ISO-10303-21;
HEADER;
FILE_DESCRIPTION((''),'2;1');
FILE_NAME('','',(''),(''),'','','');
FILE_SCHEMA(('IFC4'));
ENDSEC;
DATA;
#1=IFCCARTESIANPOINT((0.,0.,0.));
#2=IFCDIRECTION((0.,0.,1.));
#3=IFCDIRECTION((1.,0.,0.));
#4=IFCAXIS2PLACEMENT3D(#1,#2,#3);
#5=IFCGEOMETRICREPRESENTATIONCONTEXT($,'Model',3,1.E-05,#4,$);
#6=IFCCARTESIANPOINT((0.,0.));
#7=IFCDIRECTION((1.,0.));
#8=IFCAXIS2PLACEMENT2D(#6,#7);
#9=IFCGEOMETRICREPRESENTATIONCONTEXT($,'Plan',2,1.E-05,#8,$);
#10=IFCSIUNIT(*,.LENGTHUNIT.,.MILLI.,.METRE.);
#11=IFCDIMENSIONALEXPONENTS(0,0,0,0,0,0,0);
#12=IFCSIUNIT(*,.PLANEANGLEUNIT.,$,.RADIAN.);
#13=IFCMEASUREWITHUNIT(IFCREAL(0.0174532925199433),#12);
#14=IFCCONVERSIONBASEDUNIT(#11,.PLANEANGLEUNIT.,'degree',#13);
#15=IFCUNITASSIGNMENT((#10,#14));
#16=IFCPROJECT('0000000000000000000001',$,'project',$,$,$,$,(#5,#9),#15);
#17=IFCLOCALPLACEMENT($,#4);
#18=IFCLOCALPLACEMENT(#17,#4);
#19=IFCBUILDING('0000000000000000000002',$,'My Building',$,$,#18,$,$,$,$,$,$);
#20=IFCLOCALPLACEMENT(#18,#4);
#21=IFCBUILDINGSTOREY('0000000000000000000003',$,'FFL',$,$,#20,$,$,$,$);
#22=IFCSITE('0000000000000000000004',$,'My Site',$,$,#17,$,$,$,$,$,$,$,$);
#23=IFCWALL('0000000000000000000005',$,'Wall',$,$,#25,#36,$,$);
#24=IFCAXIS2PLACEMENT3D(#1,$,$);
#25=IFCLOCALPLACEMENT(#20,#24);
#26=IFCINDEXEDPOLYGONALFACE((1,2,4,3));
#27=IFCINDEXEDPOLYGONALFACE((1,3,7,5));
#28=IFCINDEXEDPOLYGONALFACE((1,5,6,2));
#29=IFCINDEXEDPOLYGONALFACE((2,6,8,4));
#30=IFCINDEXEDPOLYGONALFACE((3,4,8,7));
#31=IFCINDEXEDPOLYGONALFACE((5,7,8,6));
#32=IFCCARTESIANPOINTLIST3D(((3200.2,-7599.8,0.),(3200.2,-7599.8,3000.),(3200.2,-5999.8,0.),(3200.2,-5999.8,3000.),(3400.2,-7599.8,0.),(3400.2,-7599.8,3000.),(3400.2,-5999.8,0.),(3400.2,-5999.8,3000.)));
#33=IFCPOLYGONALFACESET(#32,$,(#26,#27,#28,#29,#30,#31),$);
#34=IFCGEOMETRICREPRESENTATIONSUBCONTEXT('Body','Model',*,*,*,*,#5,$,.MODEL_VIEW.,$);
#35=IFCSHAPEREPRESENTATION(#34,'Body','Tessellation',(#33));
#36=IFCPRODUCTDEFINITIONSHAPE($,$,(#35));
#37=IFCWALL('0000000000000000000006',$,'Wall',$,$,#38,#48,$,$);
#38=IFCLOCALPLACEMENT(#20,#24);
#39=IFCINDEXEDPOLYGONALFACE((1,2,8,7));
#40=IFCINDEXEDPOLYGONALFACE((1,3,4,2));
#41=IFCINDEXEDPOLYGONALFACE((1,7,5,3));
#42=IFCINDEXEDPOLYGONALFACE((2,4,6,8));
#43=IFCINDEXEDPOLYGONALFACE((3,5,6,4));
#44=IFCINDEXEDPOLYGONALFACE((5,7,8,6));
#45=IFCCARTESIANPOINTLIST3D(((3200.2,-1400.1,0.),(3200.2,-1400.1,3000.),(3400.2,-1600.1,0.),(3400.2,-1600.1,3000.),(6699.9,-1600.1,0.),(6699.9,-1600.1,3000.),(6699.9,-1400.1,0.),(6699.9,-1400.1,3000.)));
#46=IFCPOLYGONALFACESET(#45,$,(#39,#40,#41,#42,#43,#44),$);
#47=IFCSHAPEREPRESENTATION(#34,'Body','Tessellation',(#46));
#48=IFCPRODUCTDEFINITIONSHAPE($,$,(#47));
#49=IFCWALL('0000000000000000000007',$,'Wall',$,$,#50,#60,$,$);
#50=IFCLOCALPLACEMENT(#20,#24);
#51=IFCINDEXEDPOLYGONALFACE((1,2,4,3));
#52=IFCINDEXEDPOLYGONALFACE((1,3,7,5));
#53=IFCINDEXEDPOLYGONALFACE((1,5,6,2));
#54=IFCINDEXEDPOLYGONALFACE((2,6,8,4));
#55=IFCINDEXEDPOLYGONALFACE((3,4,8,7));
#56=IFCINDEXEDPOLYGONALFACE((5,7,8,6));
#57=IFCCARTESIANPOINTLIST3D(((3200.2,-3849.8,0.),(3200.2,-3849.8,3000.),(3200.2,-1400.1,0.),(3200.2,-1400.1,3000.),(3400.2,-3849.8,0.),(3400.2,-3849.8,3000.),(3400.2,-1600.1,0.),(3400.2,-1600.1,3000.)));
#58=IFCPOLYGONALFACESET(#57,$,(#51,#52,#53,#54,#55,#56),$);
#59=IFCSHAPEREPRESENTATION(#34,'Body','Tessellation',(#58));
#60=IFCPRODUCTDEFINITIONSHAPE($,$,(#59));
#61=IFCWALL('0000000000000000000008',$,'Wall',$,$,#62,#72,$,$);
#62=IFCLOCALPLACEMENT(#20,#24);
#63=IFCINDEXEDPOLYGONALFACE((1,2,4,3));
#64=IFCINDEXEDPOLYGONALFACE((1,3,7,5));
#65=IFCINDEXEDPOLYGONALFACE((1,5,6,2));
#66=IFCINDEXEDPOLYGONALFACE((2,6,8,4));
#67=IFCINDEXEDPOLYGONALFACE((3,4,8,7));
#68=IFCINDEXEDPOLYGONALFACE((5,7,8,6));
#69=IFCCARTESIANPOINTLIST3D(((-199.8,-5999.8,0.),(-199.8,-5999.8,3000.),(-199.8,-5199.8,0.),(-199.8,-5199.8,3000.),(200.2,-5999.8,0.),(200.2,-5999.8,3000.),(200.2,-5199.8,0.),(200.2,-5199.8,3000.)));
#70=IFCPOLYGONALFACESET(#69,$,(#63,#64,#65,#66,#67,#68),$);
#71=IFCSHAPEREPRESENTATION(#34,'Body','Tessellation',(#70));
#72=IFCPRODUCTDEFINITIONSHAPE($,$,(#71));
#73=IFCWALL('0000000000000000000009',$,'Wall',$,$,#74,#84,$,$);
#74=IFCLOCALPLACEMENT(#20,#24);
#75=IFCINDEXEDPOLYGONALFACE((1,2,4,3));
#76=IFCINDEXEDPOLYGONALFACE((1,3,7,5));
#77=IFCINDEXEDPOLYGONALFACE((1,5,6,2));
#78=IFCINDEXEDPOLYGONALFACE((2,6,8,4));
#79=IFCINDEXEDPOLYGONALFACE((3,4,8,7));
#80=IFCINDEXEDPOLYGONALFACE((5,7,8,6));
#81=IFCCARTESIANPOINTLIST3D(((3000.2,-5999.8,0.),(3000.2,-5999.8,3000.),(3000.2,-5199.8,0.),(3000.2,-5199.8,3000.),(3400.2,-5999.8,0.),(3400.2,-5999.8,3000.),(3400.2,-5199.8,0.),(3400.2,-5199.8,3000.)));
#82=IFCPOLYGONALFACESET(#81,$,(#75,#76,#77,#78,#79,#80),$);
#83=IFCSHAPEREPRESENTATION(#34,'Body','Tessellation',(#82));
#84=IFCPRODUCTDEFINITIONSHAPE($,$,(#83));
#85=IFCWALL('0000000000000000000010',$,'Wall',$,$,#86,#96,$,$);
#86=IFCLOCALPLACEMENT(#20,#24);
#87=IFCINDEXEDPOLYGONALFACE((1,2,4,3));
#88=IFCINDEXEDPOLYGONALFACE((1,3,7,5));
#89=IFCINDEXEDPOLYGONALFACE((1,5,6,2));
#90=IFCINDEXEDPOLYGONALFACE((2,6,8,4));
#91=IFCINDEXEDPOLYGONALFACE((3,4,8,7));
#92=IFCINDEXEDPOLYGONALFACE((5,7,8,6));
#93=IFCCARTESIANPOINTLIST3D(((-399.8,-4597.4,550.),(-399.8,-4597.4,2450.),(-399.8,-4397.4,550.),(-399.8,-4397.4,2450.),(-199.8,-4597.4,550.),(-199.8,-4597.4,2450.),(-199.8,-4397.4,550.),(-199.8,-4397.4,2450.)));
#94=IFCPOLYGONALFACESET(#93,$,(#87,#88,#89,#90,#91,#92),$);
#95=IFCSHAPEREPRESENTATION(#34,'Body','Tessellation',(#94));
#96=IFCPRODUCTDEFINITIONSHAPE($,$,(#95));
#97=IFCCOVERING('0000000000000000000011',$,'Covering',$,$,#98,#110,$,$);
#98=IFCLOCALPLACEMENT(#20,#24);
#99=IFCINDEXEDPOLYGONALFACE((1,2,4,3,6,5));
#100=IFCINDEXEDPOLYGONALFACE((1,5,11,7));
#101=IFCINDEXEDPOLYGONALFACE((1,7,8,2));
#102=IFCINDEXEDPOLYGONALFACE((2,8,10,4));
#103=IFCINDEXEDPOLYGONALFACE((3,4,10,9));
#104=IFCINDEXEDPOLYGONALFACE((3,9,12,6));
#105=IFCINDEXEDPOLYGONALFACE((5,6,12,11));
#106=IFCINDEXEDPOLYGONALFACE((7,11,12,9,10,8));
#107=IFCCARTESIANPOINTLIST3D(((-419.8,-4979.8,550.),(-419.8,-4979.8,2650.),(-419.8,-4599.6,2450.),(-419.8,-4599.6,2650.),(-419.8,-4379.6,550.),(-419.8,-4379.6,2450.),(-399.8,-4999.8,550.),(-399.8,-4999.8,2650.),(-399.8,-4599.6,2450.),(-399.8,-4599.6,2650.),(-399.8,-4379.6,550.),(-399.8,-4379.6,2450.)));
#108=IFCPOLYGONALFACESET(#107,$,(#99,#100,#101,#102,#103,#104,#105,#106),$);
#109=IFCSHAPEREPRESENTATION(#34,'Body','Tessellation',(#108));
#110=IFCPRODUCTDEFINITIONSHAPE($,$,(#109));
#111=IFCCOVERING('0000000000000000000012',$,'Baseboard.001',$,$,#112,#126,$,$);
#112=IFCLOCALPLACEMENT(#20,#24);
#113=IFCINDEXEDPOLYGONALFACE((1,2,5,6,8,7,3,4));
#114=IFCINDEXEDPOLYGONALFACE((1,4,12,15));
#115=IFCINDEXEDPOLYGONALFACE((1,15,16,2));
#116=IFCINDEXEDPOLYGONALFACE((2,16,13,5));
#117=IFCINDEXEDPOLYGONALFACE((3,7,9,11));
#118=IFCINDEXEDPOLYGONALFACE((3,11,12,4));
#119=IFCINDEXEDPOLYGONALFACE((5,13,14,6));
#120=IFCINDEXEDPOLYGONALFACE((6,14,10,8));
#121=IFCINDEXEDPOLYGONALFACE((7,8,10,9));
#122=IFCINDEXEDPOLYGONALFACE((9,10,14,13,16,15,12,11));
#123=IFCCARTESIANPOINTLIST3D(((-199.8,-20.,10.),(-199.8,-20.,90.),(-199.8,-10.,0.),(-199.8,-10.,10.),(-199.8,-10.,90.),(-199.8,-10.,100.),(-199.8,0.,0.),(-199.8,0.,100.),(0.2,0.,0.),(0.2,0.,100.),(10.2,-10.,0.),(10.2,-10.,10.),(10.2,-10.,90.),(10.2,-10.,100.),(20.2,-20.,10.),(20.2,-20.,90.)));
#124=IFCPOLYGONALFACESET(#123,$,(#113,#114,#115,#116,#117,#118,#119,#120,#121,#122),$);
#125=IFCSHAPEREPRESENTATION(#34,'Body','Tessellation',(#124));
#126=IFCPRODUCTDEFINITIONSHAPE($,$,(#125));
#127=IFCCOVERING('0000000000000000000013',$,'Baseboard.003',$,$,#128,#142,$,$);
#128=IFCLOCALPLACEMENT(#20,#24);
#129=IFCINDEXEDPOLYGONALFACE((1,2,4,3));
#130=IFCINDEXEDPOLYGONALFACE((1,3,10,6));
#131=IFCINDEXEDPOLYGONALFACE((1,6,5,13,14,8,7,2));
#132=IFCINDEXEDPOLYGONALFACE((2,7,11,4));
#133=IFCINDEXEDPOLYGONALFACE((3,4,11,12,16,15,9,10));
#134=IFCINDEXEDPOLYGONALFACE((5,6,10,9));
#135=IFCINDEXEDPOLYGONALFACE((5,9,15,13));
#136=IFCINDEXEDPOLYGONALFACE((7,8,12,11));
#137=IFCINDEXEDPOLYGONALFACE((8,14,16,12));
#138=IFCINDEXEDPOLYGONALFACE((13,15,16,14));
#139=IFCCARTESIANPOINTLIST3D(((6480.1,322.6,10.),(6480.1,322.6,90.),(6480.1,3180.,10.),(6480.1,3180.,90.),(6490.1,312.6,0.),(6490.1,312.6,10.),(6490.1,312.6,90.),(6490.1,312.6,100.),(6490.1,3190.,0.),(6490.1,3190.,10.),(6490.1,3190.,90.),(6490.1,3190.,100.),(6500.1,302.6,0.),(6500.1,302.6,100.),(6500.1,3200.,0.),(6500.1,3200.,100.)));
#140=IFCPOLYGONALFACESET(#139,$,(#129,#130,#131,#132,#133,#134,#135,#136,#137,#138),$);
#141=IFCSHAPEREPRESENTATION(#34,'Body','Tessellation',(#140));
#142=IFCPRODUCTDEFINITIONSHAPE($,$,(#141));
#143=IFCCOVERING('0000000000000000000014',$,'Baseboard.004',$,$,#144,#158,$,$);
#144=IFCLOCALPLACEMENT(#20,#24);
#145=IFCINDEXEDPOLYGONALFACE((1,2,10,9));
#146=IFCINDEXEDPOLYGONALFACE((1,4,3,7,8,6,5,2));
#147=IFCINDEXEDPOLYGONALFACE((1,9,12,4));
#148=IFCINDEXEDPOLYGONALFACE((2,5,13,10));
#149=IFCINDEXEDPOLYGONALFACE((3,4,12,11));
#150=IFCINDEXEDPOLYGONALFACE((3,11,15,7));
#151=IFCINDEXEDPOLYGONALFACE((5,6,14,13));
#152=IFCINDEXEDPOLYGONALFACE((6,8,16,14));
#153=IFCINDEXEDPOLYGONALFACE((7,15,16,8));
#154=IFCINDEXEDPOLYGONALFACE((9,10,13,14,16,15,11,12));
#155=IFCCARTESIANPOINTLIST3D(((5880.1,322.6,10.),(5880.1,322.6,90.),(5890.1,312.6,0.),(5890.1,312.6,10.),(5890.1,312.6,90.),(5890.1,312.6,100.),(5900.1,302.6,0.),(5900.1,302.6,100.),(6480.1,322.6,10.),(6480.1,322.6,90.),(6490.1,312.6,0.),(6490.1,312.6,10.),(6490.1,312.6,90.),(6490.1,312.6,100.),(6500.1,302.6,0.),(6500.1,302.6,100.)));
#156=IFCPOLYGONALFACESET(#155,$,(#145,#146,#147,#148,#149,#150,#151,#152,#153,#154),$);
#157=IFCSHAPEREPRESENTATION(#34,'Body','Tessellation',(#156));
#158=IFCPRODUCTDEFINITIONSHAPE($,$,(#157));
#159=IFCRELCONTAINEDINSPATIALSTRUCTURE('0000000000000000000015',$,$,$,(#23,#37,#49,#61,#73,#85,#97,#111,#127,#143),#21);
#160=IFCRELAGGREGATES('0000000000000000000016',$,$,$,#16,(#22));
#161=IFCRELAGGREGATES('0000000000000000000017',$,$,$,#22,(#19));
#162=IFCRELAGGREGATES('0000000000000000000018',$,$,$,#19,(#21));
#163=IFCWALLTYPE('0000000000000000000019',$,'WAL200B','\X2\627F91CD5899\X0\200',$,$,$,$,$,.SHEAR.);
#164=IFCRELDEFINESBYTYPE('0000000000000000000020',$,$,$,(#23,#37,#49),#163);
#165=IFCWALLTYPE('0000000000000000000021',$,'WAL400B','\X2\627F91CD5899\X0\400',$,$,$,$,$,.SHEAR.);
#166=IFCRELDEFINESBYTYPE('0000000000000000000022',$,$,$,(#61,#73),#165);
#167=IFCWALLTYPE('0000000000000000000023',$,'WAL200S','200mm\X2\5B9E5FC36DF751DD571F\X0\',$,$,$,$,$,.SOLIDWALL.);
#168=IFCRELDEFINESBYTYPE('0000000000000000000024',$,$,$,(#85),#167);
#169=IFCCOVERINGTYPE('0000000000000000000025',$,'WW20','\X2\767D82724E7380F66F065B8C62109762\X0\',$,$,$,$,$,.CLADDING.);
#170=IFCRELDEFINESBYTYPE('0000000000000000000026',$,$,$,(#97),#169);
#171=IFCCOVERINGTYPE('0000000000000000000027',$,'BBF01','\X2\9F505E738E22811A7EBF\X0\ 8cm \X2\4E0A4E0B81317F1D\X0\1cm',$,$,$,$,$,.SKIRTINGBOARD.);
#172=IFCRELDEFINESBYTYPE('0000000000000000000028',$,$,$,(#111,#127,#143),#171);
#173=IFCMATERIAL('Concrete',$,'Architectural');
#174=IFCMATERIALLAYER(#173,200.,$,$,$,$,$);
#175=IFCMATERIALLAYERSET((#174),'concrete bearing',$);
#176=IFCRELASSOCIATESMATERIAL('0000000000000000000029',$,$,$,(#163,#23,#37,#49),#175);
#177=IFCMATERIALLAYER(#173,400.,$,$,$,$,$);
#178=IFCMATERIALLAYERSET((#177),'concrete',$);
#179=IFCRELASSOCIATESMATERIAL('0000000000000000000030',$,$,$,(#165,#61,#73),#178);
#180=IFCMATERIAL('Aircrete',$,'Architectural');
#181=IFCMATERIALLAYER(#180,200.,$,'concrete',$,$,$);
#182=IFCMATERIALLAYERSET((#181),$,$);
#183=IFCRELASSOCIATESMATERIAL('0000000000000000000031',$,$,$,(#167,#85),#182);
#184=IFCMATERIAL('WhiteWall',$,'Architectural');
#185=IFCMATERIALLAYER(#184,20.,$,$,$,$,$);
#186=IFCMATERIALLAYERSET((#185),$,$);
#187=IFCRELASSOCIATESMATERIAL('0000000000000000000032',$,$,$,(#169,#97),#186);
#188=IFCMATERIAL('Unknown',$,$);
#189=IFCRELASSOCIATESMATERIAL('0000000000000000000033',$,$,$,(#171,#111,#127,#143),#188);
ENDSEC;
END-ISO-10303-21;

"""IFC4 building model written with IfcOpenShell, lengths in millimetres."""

from ifc_helpers import new_model, entity, si_unit, converted_unit, frame, origin_with_axes, origin_2d_with_axis, place, context, subcontext, project, spatial, line, indexed_curve, outline, extrude, clip, halfspace, material, layer, layer_set, layer_usage, material_profile, profile_set, profile_usage, type_object, element, save


model = new_model("IFC4")

# Units and contexts
model_context = context("Model", 3, precision=1e-05, world=origin_with_axes())
plan_context = context("Plan", 2, precision=1e-05, world=origin_2d_with_axis())
body_context_1 = subcontext(model_context, "Body", "Model", "MODEL_VIEW")
ifc_project = project(units=[si_unit("LENGTHUNIT", "METRE", prefix="MILLI"), converted_unit("PLANEANGLEUNIT", "degree", entity("IfcReal", 0.0174532925199433), si_unit("PLANEANGLEUNIT", "RADIAN"), dimensions=[0, 0, 0, 0, 0, 0, 0])], contexts=[model_context, plan_context])

# Site, building, storey
site_placement = place(None, origin_with_axes())
site = spatial("IfcSite", under=ifc_project, at=site_placement, Name="My Site")
building_placement = place(site_placement, origin_with_axes())
building = spatial("IfcBuilding", under=site, at=building_placement, Name="My Building")
storey_placement = place(building_placement, origin_with_axes())
storey = spatial("IfcBuildingStorey", under=building, at=storey_placement, Name="FFL")

# Shared definitions
ifc_material_1 = material(Name="Aircrete", Category="Architectural")

# Walls
ifc_material_2 = material(Name="Concrete", Category="Architectural")
ifc_layer_1 = layer(ifc_material_2, 200.0)
ifc_layer_set_1 = layer_set([ifc_layer_1], Name="concrete bearing")
wall_type_1 = type_object("IfcWallType", Name="WAL200B", Description="承重墙200", PredefinedType="SHEAR", material=ifc_layer_set_1)
ifc_layer_usage_1 = layer_usage(ifc_layer_set_1, "AXIS2", "NEGATIVE", 0.0)
wall_1_placement = place(storey_placement, frame((3400.2, -5999.8, 0.0), z_axis=(0.0, 0.0, 1.0), x_axis=(0.0, -1.0, 0.0)))
element("IfcWall", 1, at=wall_1_placement, inside=storey, type_object=wall_type_1, material=ifc_layer_usage_1, Name="Wall", context=body_context_1, shape_type="SweptSolid", body=[
    extrude(outline(indexed_curve([(0.0, -200.0), (0.0, 0.0), (1600.0, 0.0), (1600.0, -200.0)], segments=[line(1, 2, 3, 4, 1)])), origin_with_axes(), (0.0, 0.0, 1.0), 3000.0),
])
ifc_layer_usage_2 = layer_usage(ifc_layer_set_1, "AXIS2", "NEGATIVE", 0.0)
wall_2_placement = place(storey_placement, frame((6699.9, -1600.1, 0.0), z_axis=(0.0, 0.0, 1.0), x_axis=(-1.0, 0.000006, 0.0)))
element("IfcWall", 2, at=wall_2_placement, inside=storey, type_object=wall_type_1, material=ifc_layer_usage_2, Name="Wall", context=body_context_1, shape_type="SweptSolid", body=[
    extrude(outline(indexed_curve([(0.0, -200.0), (0.0, 0.0), (3299.7, 0.0), (3499.7, -200.0)], segments=[line(1, 2, 3, 4, 1)])), origin_with_axes(), (0.0, 0.0, 1.0), 3000.0),
])
ifc_layer_usage_3 = layer_usage(ifc_layer_set_1, "AXIS2", "NEGATIVE", 0.0)
wall_3_placement = place(storey_placement, frame((3200.2, -3849.8, 0.0), z_axis=(0.0, 0.0, 1.0), x_axis=(0.0, 1.0, 0.0)))
element("IfcWall", 3, at=wall_3_placement, inside=storey, type_object=wall_type_1, material=ifc_layer_usage_3, Name="Wall", context=body_context_1, shape_type="SweptSolid", body=[
    extrude(outline(indexed_curve([(0.0, -200.0), (0.0, 0.0), (2449.7, 0.0), (2249.7, -200.0)], segments=[line(1, 2, 3, 4, 1)])), origin_with_axes(), (0.0, 0.0, 1.0), 3000.0),
])
ifc_layer_2 = layer(ifc_material_2, 400.0)
ifc_layer_set_2 = layer_set([ifc_layer_2], Name="concrete")
ifc_layer_usage_4 = layer_usage(ifc_layer_set_2, "AXIS2", "POSITIVE", 0.0)
wall_type_2 = type_object("IfcWallType", Name="WAL400B", Description="承重墙400", PredefinedType="SHEAR", material=ifc_layer_set_2)
wall_4_placement = place(storey_placement, frame((-199.8, -5199.8, 0.0), z_axis=(0.0, 0.0, 1.0), x_axis=(0.0, -1.0, 0.0)))
element("IfcWall", 4, at=wall_4_placement, inside=storey, type_object=wall_type_2, material=ifc_layer_usage_4, Name="Wall", context=body_context_1, shape_type="SweptSolid", body=[
    extrude(outline(indexed_curve([(0.0, 0.0), (0.0, 400.0), (800.0, 400.0), (800.0, 0.0)], segments=[line(1, 2, 3, 4, 1)])), origin_with_axes(), (0.0, 0.0, 1.0), 3000.0),
])
ifc_layer_usage_5 = layer_usage(ifc_layer_set_2, "AXIS2", "POSITIVE", 0.0)
wall_5_placement = place(storey_placement, frame((3400.2, -5999.8, 0.0), z_axis=(0.0, 0.0, 1.0), x_axis=(0.000001, 1.0, 0.0)))
element("IfcWall", 5, at=wall_5_placement, inside=storey, type_object=wall_type_2, material=ifc_layer_usage_5, Name="Wall", context=body_context_1, shape_type="SweptSolid", body=[
    extrude(outline(indexed_curve([(0.0, 0.0), (0.0, 400.0), (800.0, 400.0), (800.0, 0.0)], segments=[line(1, 2, 3, 4, 1)])), origin_with_axes(), (0.0, 0.0, 1.0), 3000.0),
])
ifc_layer_3 = layer(ifc_material_1, 200.0, Name="concrete")
ifc_layer_set_3 = layer_set([ifc_layer_3])
ifc_layer_usage_6 = layer_usage(ifc_layer_set_3, "AXIS2", "NEGATIVE", 0.0)
wall_type_3 = type_object("IfcWallType", Name="WAL200S", Description="200mm实心混凝土", PredefinedType="SOLIDWALL", material=ifc_layer_set_3)
wall_6_placement = place(storey_placement, frame((-399.8, -4597.4, 550.0), z_axis=(0.0, 0.0, 1.0), x_axis=(-0.000002, 1.0, 0.0)))
element("IfcWall", 6, at=wall_6_placement, inside=storey, type_object=wall_type_3, material=ifc_layer_usage_6, Name="Wall", context=body_context_1, shape_type="SweptSolid", body=[
    extrude(outline(indexed_curve([(0.0, -200.0), (0.0, 0.0), (200.0, 0.0), (200.0, -200.0)], segments=[line(1, 2, 3, 4, 1)])), origin_with_axes(), (0.0, 0.0, 1.0), 1900.0),
])

# Covering, opening
ifc_material_3 = material(Name="WhiteWall", Category="Architectural")
ifc_layer_4 = layer(ifc_material_3, 20.0)
ifc_layer_set_4 = layer_set([ifc_layer_4])
ifc_layer_usage_7 = layer_usage(ifc_layer_set_4, "AXIS2", "POSITIVE", 0.0)
covering_type_1 = type_object("IfcCoveringType", Name="WW20", Description="白色乳胶漆完成面", PredefinedType="CLADDING", material=ifc_layer_set_4)
covering_1_placement = place(storey_placement, frame((-399.8, -4999.8, 550.0), z_axis=(0.0, 0.0, 1.0), x_axis=(0.000001, 1.0, 0.0)))
covering_1 = element("IfcCovering", 7, at=covering_1_placement, inside=storey, type_object=covering_type_1, material=ifc_layer_usage_7, Name="Covering", context=body_context_1, shape_type="SweptSolid", body=[
    extrude(outline(indexed_curve([(0.0, 0.0), (20.0, 20.0), (620.2, 20.0), (620.2, 0.0)], segments=[line(1, 2, 3, 4, 1)])), origin_with_axes(), (0.0, 0.0, 1.0), 2100.0),
])
opening_1_placement = place(covering_1_placement, frame((620.2, 120.0, 1900.0), z_axis=(0.000001, -1.0, 0.0), x_axis=(0.0, 0.0, 1.0)))
element("IfcOpeningElement", 8, at=opening_1_placement, cuts=covering_1, PredefinedType="OPENING", context=body_context_1, shape_type="SweptSolid", body=[
    extrude(outline(indexed_curve([(0.0, 220.0), (500.0, 220.0), (500.0, -100.0), (0.0, -100.0), (0.0, 220.0)])), origin_with_axes(), (0.0, 0.0, 1.0), 500.0),
])

# Coverings
ifc_material_4 = material(Name="Unknown")
ifc_material_profile = material_profile(ifc_material_4, outline(indexed_curve([(0.0, 100.0), (10.0, 100.0), (10.0, 90.0), (20.0, 90.0), (20.0, 10.0), (10.0, 10.0), (10.0, 0.0), (0.0, 0.0), (0.0, 100.0)])))
ifc_profile_set = profile_set([ifc_material_profile])
ifc_profile_usage_1 = profile_usage(ifc_profile_set, cardinal=5)
covering_type_2 = type_object("IfcCoveringType", Name="BBF01", Description="齐平踢脚线 8cm 上下脱缝1cm", PredefinedType="SKIRTINGBOARD", material=ifc_profile_set)
covering_2_placement = place(storey_placement, frame((30.2, 0.0, 0.0), z_axis=(-1.0, 0.0, 0.0), x_axis=(0.0, -1.0, 0.0)))
element("IfcCovering", 9, at=covering_2_placement, inside=storey, type_object=covering_type_2, material=ifc_profile_usage_1, Name="Baseboard.001", context=body_context_1, shape_type="Clipping", body=[
    clip(extrude(outline(indexed_curve([(0.0, 100.0), (10.0, 100.0), (10.0, 90.0), (20.0, 90.0), (20.0, 10.0), (10.0, 10.0), (10.0, 0.0), (0.0, 0.0), (0.0, 100.0)])), origin_with_axes(), (0.0, 0.0, 1.0), 230.0), halfspace(frame((30.0, 0.0, 0.0), z_axis=(-0.707107, 0.0, -0.707107), x_axis=(0.0, 1.0, 0.0)), False)),
])
ifc_profile_usage_2 = profile_usage(ifc_profile_set, cardinal=5)
covering_3_placement = place(storey_placement, frame((6500.1, 302.6, 0.0), z_axis=(0.0, 1.0, 0.0), x_axis=(-1.0, 0.0, 0.0)))
element("IfcCovering", 10, at=covering_3_placement, inside=storey, type_object=covering_type_2, material=ifc_profile_usage_2, Name="Baseboard.003", context=body_context_1, shape_type="Clipping", body=[
    clip(clip(extrude(outline(indexed_curve([(0.0, 100.0), (10.0, 100.0), (10.0, 90.0), (20.0, 90.0), (20.0, 10.0), (10.0, 10.0), (10.0, 0.0), (0.0, 0.0), (0.0, 100.0)])), origin_with_axes(), (0.0, 0.0, 1.0), 2897.4), halfspace(frame((0.0, 0.0, 0.0), z_axis=(0.707107, 0.0, -0.707106), x_axis=(0.0, -1.0, 0.0)), False)), halfspace(frame((0.0, 0.0, 2897.4), z_axis=(0.707107, 0.0, 0.707107), x_axis=(0.0, -1.0, 0.0)), False)),
])
ifc_profile_usage_3 = profile_usage(ifc_profile_set, cardinal=5)
covering_4_placement = place(storey_placement, frame((5880.1, 302.6, 0.0), z_axis=(1.0, 0.0, 0.0), x_axis=(0.0, 1.0, 0.0)))
element("IfcCovering", 11, at=covering_4_placement, inside=storey, type_object=covering_type_2, material=ifc_profile_usage_3, Name="Baseboard.004", context=body_context_1, shape_type="Clipping", body=[
    clip(clip(extrude(outline(indexed_curve([(0.0, 100.0), (10.0, 100.0), (10.0, 90.0), (20.0, 90.0), (20.0, 10.0), (10.0, 10.0), (10.0, 0.0), (0.0, 0.0), (0.0, 100.0)])), origin_with_axes(), (0.0, 0.0, 1.0), 620.0), halfspace(frame((20.0, 0.0, 0.0), z_axis=(-0.707107, 0.0, -0.707107), x_axis=(0.0, 1.0, 0.0)), False)), halfspace(frame((0.0, 0.0, 620.0), z_axis=(0.707107, 0.0, 0.707107), x_axis=(0.0, -1.0, 0.0)), False)),
])

save(model, "model.ifc")
